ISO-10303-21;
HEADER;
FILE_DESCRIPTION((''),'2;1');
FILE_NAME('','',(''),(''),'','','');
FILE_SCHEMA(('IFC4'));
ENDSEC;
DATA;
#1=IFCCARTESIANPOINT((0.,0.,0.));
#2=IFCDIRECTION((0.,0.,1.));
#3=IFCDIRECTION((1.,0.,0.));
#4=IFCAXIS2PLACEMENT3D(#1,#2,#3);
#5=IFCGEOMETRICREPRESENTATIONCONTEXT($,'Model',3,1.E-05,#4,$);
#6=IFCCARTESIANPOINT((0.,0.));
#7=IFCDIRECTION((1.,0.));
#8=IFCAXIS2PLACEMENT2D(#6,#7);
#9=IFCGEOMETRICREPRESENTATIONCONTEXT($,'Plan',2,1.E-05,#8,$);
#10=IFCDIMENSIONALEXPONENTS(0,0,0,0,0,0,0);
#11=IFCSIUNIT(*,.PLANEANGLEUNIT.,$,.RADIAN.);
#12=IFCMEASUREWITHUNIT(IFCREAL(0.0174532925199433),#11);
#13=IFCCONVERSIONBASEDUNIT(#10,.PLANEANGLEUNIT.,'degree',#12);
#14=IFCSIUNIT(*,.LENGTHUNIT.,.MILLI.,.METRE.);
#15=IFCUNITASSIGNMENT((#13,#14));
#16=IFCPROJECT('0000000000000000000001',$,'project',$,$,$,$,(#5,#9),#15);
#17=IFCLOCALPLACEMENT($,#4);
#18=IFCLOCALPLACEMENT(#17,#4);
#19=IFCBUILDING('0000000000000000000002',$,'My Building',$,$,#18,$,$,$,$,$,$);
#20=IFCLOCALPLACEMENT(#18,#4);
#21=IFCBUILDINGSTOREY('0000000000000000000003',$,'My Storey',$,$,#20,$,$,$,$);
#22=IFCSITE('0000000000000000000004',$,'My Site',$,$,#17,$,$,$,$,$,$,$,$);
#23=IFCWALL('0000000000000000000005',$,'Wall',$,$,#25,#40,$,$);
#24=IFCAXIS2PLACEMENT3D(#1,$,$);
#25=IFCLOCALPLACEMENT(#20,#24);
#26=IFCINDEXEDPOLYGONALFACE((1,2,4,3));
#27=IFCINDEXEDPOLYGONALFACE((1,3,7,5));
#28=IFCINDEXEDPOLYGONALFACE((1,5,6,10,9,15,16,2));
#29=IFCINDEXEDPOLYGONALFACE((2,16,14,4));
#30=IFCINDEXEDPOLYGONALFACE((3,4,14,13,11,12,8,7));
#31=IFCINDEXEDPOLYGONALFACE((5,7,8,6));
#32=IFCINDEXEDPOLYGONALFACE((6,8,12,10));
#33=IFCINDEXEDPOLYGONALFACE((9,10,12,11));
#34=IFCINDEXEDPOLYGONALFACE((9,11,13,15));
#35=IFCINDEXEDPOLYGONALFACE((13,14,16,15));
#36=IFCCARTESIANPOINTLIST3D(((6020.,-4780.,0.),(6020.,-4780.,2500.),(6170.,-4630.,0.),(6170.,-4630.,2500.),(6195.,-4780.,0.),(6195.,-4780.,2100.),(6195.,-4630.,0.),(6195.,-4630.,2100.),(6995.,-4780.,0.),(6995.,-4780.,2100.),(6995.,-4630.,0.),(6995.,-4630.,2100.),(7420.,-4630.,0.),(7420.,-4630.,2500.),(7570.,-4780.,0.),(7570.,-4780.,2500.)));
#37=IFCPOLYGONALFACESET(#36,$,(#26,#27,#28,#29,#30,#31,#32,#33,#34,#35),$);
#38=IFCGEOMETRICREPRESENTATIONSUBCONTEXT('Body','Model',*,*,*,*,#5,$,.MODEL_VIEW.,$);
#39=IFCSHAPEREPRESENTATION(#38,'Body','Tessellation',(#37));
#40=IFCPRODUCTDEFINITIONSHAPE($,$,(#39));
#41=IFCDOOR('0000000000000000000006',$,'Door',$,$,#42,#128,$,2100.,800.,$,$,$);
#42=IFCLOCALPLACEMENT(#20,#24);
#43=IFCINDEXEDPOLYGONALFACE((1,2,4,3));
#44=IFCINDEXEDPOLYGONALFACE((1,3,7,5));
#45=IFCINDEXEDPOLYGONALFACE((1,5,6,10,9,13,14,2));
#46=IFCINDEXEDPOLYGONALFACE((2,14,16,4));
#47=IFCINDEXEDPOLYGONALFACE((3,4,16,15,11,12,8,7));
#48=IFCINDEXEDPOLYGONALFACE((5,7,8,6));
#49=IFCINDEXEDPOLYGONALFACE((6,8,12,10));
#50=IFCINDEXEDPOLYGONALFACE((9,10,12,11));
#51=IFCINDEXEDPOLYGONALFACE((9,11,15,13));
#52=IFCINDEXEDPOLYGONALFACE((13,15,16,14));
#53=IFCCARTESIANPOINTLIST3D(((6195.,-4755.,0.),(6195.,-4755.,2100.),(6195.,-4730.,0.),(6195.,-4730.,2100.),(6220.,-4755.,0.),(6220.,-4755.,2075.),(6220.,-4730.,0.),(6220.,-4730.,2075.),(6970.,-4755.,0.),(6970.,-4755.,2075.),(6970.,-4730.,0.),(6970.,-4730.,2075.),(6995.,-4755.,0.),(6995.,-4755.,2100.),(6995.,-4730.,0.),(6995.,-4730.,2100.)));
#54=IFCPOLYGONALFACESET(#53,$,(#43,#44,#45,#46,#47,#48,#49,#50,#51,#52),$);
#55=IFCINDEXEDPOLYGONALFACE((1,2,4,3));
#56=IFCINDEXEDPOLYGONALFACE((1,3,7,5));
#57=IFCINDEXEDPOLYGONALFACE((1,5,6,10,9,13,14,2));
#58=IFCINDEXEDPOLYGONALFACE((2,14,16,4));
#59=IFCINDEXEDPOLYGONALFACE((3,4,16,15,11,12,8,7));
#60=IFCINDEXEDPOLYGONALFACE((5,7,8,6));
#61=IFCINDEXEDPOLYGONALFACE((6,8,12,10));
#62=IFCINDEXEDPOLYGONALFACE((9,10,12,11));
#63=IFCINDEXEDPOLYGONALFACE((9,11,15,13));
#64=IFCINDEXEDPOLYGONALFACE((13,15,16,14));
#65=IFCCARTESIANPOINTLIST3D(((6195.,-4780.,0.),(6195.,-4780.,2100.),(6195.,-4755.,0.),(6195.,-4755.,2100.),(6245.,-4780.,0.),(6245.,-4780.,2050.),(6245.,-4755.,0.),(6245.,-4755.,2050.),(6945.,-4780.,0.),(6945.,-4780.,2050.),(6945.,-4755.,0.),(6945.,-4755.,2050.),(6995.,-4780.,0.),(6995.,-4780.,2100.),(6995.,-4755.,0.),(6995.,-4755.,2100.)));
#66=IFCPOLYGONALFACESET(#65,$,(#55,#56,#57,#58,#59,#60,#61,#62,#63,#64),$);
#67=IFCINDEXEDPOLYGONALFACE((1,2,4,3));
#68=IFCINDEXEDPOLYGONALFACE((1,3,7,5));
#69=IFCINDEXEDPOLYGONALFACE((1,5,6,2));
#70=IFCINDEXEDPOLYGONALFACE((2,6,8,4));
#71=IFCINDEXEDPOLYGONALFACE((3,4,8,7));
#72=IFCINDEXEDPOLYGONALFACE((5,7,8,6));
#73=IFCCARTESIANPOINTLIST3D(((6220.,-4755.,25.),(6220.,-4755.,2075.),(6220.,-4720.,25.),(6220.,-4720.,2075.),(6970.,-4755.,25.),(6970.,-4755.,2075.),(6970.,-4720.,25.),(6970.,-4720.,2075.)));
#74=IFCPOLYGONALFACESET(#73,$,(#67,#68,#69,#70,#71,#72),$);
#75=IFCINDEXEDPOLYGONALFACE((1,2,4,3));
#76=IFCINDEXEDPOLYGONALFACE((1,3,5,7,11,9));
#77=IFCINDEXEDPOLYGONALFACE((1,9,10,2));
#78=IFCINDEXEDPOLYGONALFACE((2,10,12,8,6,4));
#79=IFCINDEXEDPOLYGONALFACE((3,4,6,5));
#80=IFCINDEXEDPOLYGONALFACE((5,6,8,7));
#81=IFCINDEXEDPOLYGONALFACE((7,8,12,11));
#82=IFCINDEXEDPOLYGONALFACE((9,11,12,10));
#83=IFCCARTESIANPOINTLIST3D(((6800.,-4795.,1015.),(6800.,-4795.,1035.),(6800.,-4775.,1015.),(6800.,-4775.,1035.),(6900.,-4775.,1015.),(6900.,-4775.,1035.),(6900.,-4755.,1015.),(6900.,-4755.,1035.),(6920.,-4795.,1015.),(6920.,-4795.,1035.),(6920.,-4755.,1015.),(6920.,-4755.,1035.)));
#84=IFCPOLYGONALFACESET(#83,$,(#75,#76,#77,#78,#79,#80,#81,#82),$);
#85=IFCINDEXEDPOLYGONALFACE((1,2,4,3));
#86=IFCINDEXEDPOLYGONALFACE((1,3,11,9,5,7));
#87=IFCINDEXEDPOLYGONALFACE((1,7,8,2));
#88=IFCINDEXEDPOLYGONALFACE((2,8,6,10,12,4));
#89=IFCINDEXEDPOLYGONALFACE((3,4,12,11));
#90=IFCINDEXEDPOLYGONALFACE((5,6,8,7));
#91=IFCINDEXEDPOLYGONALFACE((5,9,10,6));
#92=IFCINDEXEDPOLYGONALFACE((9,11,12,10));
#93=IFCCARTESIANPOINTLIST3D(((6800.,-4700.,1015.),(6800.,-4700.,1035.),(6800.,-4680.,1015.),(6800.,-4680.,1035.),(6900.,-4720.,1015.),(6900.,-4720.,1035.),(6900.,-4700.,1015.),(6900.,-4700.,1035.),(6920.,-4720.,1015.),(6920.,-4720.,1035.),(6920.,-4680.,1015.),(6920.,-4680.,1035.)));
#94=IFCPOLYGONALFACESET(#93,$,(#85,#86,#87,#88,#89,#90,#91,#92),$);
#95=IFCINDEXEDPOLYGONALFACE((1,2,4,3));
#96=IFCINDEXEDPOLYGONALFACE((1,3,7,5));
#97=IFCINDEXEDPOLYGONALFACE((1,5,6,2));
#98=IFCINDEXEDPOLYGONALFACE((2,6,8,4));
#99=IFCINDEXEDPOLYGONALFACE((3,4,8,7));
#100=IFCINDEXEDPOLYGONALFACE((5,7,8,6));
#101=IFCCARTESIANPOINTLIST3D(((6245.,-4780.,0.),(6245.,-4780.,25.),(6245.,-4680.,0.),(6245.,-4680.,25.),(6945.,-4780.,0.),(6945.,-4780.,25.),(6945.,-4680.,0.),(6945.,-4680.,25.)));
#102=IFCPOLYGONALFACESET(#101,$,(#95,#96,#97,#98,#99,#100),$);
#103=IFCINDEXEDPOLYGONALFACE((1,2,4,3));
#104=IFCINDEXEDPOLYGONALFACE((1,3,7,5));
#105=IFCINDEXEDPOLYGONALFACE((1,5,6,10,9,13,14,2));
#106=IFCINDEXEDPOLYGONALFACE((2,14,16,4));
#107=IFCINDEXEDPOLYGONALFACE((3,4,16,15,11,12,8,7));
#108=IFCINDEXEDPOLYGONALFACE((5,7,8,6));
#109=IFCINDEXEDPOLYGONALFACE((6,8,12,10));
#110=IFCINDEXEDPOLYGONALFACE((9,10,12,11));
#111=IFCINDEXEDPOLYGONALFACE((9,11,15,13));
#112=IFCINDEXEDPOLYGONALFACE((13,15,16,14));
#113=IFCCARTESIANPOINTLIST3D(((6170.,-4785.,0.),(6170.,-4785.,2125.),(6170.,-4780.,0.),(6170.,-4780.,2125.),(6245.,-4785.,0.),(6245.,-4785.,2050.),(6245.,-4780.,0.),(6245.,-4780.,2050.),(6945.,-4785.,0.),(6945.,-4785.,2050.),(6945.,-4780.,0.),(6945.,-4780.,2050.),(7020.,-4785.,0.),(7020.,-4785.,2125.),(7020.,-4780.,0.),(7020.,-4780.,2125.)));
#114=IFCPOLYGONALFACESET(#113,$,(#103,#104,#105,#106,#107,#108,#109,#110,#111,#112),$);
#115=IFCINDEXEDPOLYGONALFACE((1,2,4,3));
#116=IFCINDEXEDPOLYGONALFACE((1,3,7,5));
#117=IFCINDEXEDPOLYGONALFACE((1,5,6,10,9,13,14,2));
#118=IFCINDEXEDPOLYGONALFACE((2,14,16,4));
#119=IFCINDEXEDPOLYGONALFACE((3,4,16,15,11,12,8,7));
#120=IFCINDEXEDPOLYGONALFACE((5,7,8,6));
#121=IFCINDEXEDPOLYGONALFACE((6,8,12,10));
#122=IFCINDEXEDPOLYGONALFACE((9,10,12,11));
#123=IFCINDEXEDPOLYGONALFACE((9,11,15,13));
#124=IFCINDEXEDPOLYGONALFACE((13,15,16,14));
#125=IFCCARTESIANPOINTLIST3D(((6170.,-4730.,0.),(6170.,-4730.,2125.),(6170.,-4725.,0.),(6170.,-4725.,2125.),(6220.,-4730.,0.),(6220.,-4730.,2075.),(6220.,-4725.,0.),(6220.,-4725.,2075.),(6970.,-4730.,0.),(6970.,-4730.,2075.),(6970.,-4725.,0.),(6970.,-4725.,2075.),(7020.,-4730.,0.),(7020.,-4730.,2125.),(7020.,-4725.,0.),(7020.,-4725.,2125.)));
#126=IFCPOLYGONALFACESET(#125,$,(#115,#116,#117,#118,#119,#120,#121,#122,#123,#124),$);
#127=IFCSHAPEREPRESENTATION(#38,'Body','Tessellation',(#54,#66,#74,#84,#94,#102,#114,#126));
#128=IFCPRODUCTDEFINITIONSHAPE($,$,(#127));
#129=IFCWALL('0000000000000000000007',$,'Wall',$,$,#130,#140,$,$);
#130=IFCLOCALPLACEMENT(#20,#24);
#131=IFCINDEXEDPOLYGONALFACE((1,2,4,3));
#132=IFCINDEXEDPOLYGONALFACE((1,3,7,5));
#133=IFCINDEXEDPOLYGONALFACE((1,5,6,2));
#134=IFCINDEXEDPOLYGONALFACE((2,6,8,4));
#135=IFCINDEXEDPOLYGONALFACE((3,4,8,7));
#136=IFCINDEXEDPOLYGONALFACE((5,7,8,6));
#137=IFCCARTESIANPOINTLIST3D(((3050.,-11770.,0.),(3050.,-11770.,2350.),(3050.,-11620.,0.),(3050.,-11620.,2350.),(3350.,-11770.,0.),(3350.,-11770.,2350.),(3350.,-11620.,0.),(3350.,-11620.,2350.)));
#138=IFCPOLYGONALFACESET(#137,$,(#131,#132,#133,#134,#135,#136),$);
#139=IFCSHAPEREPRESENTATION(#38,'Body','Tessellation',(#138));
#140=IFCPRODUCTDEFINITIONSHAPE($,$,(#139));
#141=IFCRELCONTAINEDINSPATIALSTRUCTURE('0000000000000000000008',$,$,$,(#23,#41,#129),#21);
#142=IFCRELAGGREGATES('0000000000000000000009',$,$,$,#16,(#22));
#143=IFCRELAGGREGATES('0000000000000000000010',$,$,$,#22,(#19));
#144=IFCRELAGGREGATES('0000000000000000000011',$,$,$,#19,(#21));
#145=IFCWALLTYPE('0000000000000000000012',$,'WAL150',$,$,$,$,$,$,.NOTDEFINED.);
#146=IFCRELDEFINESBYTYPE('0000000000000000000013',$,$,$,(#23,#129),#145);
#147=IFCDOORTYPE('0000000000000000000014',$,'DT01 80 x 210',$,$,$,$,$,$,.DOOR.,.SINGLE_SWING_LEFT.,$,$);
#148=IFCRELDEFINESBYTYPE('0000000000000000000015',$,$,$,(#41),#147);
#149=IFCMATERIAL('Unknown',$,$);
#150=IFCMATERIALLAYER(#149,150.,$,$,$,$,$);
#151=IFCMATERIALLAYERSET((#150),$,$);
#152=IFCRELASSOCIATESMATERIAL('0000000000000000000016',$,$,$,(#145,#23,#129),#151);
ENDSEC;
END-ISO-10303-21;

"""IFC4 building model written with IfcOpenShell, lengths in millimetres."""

from ifc_helpers import new_model, entity, si_unit, converted_unit, frame, origin_with_axes, origin_2d_with_axis, place, context, subcontext, project, spatial, line, indexed_curve, outline, extrude, shape, source, transform, mapped, material, layer, layer_set, layer_usage, type_object, type_shapes, element, fill, save


model = new_model("IFC4")

# Units and contexts
model_context = context("Model", 3, precision=1e-05, world=origin_with_axes())
plan_context = context("Plan", 2, precision=1e-05, world=origin_2d_with_axis())
body_context_1 = subcontext(model_context, "Body", "Model", "MODEL_VIEW")
body_context_2 = subcontext(plan_context, "Body", "Plan", "PLAN_VIEW")
ifc_project = project(units=[converted_unit("PLANEANGLEUNIT", "degree", entity("IfcReal", 0.0174532925199433), si_unit("PLANEANGLEUNIT", "RADIAN"), dimensions=[0, 0, 0, 0, 0, 0, 0]), si_unit("LENGTHUNIT", "METRE", prefix="MILLI")], contexts=[model_context, plan_context])

# Site, building, storey
site_placement = place(None, origin_with_axes())
site = spatial("IfcSite", under=ifc_project, at=site_placement, Name="My Site")
building_placement = place(site_placement, origin_with_axes())
building = spatial("IfcBuilding", under=site, at=building_placement, Name="My Building")
storey_placement = place(building_placement, origin_with_axes())
storey = spatial("IfcBuildingStorey", under=building, at=storey_placement, Name="My Storey")

# Shared definitions
ifc_material = material(Name="Unknown")

# Shared definitions
ifc_layer_1 = layer(ifc_material, 150.0)
ifc_layer_set_1 = layer_set([ifc_layer_1])
wall_type_1 = type_object("IfcWallType", Name="WAL150", PredefinedType="NOTDEFINED", material=ifc_layer_set_1)

# Shared definitions
shared_shape_1 = source(origin_with_axes(), body_context_1, "Body", "SweptSolid", [
    extrude(outline(indexed_curve([(0.0, 0.0), (800.0, 0.0), (800.0, 2100.0), (0.0, 2100.0)], segments=[line(1, 2, 3, 4, 1)])), frame((0.0, -600.0, 0.0), z_axis=(0.0, -1.0, 0.0), x_axis=(1.0, 0.0, 0.0)), (0.0, 0.0, -1.0), 1200.0),
])
door_type = type_object("IfcDoorType", Name="DT01 80 x 210", OperationType="SINGLE_SWING_LEFT", PredefinedType="DOOR")
shared_shape_2 = source(origin_with_axes(), body_context_1, "Body", "SweptSolid", [
    extrude(outline(indexed_curve([(0.0, 0.0), (0.0, 2100.0), (800.0, 2100.0), (800.0, 0.0), (775.0, 0.0), (775.0, 2075.0), (25.0, 2075.0), (25.0, 0.0)], segments=[line(1, 2, 3, 4, 5, 6, 7, 8, 1)])), frame((0.0, 25.0, 0.0), z_axis=(0.0, -1.0, 0.0), x_axis=(1.0, 0.0, 0.0)), (0.0, 0.0, -1.0), 25.0),
    extrude(outline(indexed_curve([(0.0, 0.0), (0.0, 2100.0), (800.0, 2100.0), (800.0, 0.0), (750.0, 0.0), (750.0, 2050.0), (50.0, 2050.0), (50.0, 0.0)], segments=[line(1, 2, 3, 4, 5, 6, 7, 8, 1)])), frame((0.0, 0.0, 0.0), z_axis=(0.0, -1.0, 0.0), x_axis=(1.0, 0.0, 0.0)), (0.0, 0.0, -1.0), 25.0),
    extrude(outline(indexed_curve([(0.0, 0.0), (750.0, 0.0), (750.0, 35.0), (0.0, 35.0)], segments=[line(1, 2, 3, 4, 1)])), frame((25.0, 25.0, 25.0), z_axis=(0.0, 0.0, 1.0), x_axis=(1.0, 0.0, 0.0)), (0.0, 0.0, 1.0), 2050.0),
    extrude(outline(indexed_curve([(0.0, 0.0), (0.0, -40.0), (-120.0, -40.0), (-120.0, -20.0), (-20.0, -20.0), (-20.0, 0.0)], segments=[line(1, 2, 3, 4, 5, 6, 1)])), frame((725.0, 25.0, 1015.0), z_axis=(0.0, 0.0, 1.0), x_axis=(1.0, 0.0, 0.0)), (0.0, 0.0, 1.0), 20.0),
    extrude(outline(indexed_curve([(0.0, 0.0), (0.0, 40.0), (-120.0, 40.0), (-120.0, 20.0), (-20.0, 20.0), (-20.0, 0.0)], segments=[line(1, 2, 3, 4, 5, 6, 1)])), frame((725.0, 60.0, 1015.0), z_axis=(0.0, 0.0, 1.0), x_axis=(1.0, 0.0, 0.0)), (0.0, 0.0, 1.0), 20.0),
    extrude(outline(indexed_curve([(0.0, 0.0), (700.0, 0.0), (700.0, 100.0), (0.0, 100.0), (0.0, 0.0)])), frame((50.0, 0.0, 0.0), z_axis=(0.0, 0.0, 1.0), x_axis=(1.0, 0.0, 0.0)), (0.0, 0.0, 1.0), 25.0),
    extrude(outline(indexed_curve([(75.0, 0.0), (75.0, 2050.0), (775.0, 2050.0), (775.0, 0.0), (850.0, 0.0), (850.0, 2125.0), (0.0, 2125.0), (0.0, 0.0), (75.0, 0.0)])), frame((-25.0, -5.0, 0.0), z_axis=(0.0, -1.0, 0.0), x_axis=(1.0, 0.0, 0.0)), (0.0, 0.0, -1.0), 5.0),
    extrude(outline(indexed_curve([(50.0, 0.0), (50.0, 2075.0), (800.0, 2075.0), (800.0, 0.0), (850.0, 0.0), (850.0, 2125.0), (0.0, 2125.0), (0.0, 0.0), (50.0, 0.0)])), frame((-25.0, 50.0, 0.0), z_axis=(0.0, -1.0, 0.0), x_axis=(1.0, 0.0, 0.0)), (0.0, 0.0, -1.0), 5.0),
])
shared_shape_3 = source(origin_with_axes(), body_context_2, "Body", "Curve2D", [
    entity("IfcIndexedPolyCurve", entity("IfcCartesianPointList2D", [[0.0, 0.0], [0.0, 50.0], [25.0, 50.0], [25.0, 25.0], [50.0, 25.0], [50.0, 0.0]]), [entity("IfcLineIndex", [1, 2, 3, 4, 5, 6, 1])]),
    entity("IfcIndexedPolyCurve", entity("IfcCartesianPointList2D", [[800.0, 0.0], [800.0, 50.0], [775.0, 50.0], [775.0, 25.0], [750.0, 25.0], [750.0, 0.0]]), [entity("IfcLineIndex", [1, 2, 3, 4, 5, 6, 1])]),
    entity("IfcTrimmedCurve", entity("IfcEllipse", entity("IfcAxis2Placement2D", entity("IfcCartesianPoint", [60.0, 50.0]), entity("IfcDirection", [1.0, 0.0])), 715.0, 750.0), [entity("IfcCartesianPoint", [775.0, 50.0])], [entity("IfcCartesianPoint", [60.0, 800.0])], True, "CARTESIAN"),
    entity("IfcIndexedPolyCurve", entity("IfcCartesianPointList2D", [[25.0, 50.0], [60.0, 50.0], [60.0, 800.0], [25.0, 800.0]]), [entity("IfcLineIndex", [1, 2, 3, 4, 1])]),
])
type_shapes(door_type, [shared_shape_2, shared_shape_3])

# Wall, opening, door
ifc_layer_usage_1 = layer_usage(ifc_layer_set_1, "AXIS2", "POSITIVE", 0.0)
wall_1_placement = place(storey_placement, frame((6020.0, -4780.0, 0.0), z_axis=(0.0, 0.0, 1.0), x_axis=(1.0, 0.000019, 0.0)))
wall_1 = element("IfcWall", 1, at=wall_1_placement, inside=storey, type_object=wall_type_1, material=ifc_layer_usage_1, Name="Wall", context=body_context_1, shape_type="SweptSolid", body=[
    extrude(outline(indexed_curve([(0.0, 0.0), (150.0, 150.0), (1400.0, 150.0), (1550.0, 0.0)], segments=[line(1, 2, 3, 4, 1)])), origin_with_axes(), (0.0, 0.0, 1.0), 2500.0),
])
opening_1_placement = place(wall_1_placement, frame((175.0, 0.0, 0.0), z_axis=(0.0, 0.0, 1.0), x_axis=(1.0, 0.0, 0.0)))
opening_1 = element("IfcOpeningElement", 2, at=opening_1_placement, cuts=wall_1, PredefinedType="OPENING", context=body_context_1, shape_type="MappedRepresentation", body=[
    mapped(shared_shape_1, transform((0.0, 0.0, 0.0), x_axis=(1.0, 0.0, 0.0), y_axis=(0.0, 1.0, 0.0), z_axis=(0.0, 0.0, 1.0), scale=1.0)),
])
door_1_placement = place(opening_1_placement, frame((0.0, 0.0, 0.0), z_axis=(0.0, 0.0, 1.0), x_axis=(1.0, 0.0, 0.0)))
door_1 = element("IfcDoor", 3, at=door_1_placement, inside=storey, type_object=door_type, Name="Door", OverallHeight=2100.0, OverallWidth=800.0, shapes=[
    shape(body_context_1, "Body", "MappedRepresentation", [mapped(shared_shape_2, transform((0.0, 0.0, 0.0), x_axis=(1.0, 0.0, 0.0), y_axis=(0.0, 1.0, 0.0), z_axis=(0.0, 0.0, 1.0), scale=1.0))]),
    shape(body_context_2, "Body", "MappedRepresentation", [mapped(shared_shape_3, transform((0.0, 0.0, 0.0), x_axis=(1.0, 0.0, 0.0), y_axis=(0.0, 1.0, 0.0), z_axis=(0.0, 0.0, 1.0), scale=1.0))]),
])
fill(opening_1, door_1)

# Wall
ifc_layer_usage_2 = layer_usage(ifc_layer_set_1, "AXIS2", "POSITIVE", 0.0)
wall_2_placement = place(storey_placement, frame((3050.0, -11770.0, 0.0), z_axis=(0.0, 0.0, 1.0), x_axis=(1.0, 0.0, 0.0)))
element("IfcWall", 4, at=wall_2_placement, inside=storey, type_object=wall_type_1, material=ifc_layer_usage_2, Name="Wall", context=body_context_1, shape_type="SweptSolid", body=[
    extrude(outline(indexed_curve([(0.0, 0.0), (0.0, 150.0), (300.0, 150.0), (300.0, 0.0)], segments=[line(1, 2, 3, 4, 1)])), origin_with_axes(), (0.0, 0.0, 1.0), 2350.0),
])

save(model, "model.ifc")
